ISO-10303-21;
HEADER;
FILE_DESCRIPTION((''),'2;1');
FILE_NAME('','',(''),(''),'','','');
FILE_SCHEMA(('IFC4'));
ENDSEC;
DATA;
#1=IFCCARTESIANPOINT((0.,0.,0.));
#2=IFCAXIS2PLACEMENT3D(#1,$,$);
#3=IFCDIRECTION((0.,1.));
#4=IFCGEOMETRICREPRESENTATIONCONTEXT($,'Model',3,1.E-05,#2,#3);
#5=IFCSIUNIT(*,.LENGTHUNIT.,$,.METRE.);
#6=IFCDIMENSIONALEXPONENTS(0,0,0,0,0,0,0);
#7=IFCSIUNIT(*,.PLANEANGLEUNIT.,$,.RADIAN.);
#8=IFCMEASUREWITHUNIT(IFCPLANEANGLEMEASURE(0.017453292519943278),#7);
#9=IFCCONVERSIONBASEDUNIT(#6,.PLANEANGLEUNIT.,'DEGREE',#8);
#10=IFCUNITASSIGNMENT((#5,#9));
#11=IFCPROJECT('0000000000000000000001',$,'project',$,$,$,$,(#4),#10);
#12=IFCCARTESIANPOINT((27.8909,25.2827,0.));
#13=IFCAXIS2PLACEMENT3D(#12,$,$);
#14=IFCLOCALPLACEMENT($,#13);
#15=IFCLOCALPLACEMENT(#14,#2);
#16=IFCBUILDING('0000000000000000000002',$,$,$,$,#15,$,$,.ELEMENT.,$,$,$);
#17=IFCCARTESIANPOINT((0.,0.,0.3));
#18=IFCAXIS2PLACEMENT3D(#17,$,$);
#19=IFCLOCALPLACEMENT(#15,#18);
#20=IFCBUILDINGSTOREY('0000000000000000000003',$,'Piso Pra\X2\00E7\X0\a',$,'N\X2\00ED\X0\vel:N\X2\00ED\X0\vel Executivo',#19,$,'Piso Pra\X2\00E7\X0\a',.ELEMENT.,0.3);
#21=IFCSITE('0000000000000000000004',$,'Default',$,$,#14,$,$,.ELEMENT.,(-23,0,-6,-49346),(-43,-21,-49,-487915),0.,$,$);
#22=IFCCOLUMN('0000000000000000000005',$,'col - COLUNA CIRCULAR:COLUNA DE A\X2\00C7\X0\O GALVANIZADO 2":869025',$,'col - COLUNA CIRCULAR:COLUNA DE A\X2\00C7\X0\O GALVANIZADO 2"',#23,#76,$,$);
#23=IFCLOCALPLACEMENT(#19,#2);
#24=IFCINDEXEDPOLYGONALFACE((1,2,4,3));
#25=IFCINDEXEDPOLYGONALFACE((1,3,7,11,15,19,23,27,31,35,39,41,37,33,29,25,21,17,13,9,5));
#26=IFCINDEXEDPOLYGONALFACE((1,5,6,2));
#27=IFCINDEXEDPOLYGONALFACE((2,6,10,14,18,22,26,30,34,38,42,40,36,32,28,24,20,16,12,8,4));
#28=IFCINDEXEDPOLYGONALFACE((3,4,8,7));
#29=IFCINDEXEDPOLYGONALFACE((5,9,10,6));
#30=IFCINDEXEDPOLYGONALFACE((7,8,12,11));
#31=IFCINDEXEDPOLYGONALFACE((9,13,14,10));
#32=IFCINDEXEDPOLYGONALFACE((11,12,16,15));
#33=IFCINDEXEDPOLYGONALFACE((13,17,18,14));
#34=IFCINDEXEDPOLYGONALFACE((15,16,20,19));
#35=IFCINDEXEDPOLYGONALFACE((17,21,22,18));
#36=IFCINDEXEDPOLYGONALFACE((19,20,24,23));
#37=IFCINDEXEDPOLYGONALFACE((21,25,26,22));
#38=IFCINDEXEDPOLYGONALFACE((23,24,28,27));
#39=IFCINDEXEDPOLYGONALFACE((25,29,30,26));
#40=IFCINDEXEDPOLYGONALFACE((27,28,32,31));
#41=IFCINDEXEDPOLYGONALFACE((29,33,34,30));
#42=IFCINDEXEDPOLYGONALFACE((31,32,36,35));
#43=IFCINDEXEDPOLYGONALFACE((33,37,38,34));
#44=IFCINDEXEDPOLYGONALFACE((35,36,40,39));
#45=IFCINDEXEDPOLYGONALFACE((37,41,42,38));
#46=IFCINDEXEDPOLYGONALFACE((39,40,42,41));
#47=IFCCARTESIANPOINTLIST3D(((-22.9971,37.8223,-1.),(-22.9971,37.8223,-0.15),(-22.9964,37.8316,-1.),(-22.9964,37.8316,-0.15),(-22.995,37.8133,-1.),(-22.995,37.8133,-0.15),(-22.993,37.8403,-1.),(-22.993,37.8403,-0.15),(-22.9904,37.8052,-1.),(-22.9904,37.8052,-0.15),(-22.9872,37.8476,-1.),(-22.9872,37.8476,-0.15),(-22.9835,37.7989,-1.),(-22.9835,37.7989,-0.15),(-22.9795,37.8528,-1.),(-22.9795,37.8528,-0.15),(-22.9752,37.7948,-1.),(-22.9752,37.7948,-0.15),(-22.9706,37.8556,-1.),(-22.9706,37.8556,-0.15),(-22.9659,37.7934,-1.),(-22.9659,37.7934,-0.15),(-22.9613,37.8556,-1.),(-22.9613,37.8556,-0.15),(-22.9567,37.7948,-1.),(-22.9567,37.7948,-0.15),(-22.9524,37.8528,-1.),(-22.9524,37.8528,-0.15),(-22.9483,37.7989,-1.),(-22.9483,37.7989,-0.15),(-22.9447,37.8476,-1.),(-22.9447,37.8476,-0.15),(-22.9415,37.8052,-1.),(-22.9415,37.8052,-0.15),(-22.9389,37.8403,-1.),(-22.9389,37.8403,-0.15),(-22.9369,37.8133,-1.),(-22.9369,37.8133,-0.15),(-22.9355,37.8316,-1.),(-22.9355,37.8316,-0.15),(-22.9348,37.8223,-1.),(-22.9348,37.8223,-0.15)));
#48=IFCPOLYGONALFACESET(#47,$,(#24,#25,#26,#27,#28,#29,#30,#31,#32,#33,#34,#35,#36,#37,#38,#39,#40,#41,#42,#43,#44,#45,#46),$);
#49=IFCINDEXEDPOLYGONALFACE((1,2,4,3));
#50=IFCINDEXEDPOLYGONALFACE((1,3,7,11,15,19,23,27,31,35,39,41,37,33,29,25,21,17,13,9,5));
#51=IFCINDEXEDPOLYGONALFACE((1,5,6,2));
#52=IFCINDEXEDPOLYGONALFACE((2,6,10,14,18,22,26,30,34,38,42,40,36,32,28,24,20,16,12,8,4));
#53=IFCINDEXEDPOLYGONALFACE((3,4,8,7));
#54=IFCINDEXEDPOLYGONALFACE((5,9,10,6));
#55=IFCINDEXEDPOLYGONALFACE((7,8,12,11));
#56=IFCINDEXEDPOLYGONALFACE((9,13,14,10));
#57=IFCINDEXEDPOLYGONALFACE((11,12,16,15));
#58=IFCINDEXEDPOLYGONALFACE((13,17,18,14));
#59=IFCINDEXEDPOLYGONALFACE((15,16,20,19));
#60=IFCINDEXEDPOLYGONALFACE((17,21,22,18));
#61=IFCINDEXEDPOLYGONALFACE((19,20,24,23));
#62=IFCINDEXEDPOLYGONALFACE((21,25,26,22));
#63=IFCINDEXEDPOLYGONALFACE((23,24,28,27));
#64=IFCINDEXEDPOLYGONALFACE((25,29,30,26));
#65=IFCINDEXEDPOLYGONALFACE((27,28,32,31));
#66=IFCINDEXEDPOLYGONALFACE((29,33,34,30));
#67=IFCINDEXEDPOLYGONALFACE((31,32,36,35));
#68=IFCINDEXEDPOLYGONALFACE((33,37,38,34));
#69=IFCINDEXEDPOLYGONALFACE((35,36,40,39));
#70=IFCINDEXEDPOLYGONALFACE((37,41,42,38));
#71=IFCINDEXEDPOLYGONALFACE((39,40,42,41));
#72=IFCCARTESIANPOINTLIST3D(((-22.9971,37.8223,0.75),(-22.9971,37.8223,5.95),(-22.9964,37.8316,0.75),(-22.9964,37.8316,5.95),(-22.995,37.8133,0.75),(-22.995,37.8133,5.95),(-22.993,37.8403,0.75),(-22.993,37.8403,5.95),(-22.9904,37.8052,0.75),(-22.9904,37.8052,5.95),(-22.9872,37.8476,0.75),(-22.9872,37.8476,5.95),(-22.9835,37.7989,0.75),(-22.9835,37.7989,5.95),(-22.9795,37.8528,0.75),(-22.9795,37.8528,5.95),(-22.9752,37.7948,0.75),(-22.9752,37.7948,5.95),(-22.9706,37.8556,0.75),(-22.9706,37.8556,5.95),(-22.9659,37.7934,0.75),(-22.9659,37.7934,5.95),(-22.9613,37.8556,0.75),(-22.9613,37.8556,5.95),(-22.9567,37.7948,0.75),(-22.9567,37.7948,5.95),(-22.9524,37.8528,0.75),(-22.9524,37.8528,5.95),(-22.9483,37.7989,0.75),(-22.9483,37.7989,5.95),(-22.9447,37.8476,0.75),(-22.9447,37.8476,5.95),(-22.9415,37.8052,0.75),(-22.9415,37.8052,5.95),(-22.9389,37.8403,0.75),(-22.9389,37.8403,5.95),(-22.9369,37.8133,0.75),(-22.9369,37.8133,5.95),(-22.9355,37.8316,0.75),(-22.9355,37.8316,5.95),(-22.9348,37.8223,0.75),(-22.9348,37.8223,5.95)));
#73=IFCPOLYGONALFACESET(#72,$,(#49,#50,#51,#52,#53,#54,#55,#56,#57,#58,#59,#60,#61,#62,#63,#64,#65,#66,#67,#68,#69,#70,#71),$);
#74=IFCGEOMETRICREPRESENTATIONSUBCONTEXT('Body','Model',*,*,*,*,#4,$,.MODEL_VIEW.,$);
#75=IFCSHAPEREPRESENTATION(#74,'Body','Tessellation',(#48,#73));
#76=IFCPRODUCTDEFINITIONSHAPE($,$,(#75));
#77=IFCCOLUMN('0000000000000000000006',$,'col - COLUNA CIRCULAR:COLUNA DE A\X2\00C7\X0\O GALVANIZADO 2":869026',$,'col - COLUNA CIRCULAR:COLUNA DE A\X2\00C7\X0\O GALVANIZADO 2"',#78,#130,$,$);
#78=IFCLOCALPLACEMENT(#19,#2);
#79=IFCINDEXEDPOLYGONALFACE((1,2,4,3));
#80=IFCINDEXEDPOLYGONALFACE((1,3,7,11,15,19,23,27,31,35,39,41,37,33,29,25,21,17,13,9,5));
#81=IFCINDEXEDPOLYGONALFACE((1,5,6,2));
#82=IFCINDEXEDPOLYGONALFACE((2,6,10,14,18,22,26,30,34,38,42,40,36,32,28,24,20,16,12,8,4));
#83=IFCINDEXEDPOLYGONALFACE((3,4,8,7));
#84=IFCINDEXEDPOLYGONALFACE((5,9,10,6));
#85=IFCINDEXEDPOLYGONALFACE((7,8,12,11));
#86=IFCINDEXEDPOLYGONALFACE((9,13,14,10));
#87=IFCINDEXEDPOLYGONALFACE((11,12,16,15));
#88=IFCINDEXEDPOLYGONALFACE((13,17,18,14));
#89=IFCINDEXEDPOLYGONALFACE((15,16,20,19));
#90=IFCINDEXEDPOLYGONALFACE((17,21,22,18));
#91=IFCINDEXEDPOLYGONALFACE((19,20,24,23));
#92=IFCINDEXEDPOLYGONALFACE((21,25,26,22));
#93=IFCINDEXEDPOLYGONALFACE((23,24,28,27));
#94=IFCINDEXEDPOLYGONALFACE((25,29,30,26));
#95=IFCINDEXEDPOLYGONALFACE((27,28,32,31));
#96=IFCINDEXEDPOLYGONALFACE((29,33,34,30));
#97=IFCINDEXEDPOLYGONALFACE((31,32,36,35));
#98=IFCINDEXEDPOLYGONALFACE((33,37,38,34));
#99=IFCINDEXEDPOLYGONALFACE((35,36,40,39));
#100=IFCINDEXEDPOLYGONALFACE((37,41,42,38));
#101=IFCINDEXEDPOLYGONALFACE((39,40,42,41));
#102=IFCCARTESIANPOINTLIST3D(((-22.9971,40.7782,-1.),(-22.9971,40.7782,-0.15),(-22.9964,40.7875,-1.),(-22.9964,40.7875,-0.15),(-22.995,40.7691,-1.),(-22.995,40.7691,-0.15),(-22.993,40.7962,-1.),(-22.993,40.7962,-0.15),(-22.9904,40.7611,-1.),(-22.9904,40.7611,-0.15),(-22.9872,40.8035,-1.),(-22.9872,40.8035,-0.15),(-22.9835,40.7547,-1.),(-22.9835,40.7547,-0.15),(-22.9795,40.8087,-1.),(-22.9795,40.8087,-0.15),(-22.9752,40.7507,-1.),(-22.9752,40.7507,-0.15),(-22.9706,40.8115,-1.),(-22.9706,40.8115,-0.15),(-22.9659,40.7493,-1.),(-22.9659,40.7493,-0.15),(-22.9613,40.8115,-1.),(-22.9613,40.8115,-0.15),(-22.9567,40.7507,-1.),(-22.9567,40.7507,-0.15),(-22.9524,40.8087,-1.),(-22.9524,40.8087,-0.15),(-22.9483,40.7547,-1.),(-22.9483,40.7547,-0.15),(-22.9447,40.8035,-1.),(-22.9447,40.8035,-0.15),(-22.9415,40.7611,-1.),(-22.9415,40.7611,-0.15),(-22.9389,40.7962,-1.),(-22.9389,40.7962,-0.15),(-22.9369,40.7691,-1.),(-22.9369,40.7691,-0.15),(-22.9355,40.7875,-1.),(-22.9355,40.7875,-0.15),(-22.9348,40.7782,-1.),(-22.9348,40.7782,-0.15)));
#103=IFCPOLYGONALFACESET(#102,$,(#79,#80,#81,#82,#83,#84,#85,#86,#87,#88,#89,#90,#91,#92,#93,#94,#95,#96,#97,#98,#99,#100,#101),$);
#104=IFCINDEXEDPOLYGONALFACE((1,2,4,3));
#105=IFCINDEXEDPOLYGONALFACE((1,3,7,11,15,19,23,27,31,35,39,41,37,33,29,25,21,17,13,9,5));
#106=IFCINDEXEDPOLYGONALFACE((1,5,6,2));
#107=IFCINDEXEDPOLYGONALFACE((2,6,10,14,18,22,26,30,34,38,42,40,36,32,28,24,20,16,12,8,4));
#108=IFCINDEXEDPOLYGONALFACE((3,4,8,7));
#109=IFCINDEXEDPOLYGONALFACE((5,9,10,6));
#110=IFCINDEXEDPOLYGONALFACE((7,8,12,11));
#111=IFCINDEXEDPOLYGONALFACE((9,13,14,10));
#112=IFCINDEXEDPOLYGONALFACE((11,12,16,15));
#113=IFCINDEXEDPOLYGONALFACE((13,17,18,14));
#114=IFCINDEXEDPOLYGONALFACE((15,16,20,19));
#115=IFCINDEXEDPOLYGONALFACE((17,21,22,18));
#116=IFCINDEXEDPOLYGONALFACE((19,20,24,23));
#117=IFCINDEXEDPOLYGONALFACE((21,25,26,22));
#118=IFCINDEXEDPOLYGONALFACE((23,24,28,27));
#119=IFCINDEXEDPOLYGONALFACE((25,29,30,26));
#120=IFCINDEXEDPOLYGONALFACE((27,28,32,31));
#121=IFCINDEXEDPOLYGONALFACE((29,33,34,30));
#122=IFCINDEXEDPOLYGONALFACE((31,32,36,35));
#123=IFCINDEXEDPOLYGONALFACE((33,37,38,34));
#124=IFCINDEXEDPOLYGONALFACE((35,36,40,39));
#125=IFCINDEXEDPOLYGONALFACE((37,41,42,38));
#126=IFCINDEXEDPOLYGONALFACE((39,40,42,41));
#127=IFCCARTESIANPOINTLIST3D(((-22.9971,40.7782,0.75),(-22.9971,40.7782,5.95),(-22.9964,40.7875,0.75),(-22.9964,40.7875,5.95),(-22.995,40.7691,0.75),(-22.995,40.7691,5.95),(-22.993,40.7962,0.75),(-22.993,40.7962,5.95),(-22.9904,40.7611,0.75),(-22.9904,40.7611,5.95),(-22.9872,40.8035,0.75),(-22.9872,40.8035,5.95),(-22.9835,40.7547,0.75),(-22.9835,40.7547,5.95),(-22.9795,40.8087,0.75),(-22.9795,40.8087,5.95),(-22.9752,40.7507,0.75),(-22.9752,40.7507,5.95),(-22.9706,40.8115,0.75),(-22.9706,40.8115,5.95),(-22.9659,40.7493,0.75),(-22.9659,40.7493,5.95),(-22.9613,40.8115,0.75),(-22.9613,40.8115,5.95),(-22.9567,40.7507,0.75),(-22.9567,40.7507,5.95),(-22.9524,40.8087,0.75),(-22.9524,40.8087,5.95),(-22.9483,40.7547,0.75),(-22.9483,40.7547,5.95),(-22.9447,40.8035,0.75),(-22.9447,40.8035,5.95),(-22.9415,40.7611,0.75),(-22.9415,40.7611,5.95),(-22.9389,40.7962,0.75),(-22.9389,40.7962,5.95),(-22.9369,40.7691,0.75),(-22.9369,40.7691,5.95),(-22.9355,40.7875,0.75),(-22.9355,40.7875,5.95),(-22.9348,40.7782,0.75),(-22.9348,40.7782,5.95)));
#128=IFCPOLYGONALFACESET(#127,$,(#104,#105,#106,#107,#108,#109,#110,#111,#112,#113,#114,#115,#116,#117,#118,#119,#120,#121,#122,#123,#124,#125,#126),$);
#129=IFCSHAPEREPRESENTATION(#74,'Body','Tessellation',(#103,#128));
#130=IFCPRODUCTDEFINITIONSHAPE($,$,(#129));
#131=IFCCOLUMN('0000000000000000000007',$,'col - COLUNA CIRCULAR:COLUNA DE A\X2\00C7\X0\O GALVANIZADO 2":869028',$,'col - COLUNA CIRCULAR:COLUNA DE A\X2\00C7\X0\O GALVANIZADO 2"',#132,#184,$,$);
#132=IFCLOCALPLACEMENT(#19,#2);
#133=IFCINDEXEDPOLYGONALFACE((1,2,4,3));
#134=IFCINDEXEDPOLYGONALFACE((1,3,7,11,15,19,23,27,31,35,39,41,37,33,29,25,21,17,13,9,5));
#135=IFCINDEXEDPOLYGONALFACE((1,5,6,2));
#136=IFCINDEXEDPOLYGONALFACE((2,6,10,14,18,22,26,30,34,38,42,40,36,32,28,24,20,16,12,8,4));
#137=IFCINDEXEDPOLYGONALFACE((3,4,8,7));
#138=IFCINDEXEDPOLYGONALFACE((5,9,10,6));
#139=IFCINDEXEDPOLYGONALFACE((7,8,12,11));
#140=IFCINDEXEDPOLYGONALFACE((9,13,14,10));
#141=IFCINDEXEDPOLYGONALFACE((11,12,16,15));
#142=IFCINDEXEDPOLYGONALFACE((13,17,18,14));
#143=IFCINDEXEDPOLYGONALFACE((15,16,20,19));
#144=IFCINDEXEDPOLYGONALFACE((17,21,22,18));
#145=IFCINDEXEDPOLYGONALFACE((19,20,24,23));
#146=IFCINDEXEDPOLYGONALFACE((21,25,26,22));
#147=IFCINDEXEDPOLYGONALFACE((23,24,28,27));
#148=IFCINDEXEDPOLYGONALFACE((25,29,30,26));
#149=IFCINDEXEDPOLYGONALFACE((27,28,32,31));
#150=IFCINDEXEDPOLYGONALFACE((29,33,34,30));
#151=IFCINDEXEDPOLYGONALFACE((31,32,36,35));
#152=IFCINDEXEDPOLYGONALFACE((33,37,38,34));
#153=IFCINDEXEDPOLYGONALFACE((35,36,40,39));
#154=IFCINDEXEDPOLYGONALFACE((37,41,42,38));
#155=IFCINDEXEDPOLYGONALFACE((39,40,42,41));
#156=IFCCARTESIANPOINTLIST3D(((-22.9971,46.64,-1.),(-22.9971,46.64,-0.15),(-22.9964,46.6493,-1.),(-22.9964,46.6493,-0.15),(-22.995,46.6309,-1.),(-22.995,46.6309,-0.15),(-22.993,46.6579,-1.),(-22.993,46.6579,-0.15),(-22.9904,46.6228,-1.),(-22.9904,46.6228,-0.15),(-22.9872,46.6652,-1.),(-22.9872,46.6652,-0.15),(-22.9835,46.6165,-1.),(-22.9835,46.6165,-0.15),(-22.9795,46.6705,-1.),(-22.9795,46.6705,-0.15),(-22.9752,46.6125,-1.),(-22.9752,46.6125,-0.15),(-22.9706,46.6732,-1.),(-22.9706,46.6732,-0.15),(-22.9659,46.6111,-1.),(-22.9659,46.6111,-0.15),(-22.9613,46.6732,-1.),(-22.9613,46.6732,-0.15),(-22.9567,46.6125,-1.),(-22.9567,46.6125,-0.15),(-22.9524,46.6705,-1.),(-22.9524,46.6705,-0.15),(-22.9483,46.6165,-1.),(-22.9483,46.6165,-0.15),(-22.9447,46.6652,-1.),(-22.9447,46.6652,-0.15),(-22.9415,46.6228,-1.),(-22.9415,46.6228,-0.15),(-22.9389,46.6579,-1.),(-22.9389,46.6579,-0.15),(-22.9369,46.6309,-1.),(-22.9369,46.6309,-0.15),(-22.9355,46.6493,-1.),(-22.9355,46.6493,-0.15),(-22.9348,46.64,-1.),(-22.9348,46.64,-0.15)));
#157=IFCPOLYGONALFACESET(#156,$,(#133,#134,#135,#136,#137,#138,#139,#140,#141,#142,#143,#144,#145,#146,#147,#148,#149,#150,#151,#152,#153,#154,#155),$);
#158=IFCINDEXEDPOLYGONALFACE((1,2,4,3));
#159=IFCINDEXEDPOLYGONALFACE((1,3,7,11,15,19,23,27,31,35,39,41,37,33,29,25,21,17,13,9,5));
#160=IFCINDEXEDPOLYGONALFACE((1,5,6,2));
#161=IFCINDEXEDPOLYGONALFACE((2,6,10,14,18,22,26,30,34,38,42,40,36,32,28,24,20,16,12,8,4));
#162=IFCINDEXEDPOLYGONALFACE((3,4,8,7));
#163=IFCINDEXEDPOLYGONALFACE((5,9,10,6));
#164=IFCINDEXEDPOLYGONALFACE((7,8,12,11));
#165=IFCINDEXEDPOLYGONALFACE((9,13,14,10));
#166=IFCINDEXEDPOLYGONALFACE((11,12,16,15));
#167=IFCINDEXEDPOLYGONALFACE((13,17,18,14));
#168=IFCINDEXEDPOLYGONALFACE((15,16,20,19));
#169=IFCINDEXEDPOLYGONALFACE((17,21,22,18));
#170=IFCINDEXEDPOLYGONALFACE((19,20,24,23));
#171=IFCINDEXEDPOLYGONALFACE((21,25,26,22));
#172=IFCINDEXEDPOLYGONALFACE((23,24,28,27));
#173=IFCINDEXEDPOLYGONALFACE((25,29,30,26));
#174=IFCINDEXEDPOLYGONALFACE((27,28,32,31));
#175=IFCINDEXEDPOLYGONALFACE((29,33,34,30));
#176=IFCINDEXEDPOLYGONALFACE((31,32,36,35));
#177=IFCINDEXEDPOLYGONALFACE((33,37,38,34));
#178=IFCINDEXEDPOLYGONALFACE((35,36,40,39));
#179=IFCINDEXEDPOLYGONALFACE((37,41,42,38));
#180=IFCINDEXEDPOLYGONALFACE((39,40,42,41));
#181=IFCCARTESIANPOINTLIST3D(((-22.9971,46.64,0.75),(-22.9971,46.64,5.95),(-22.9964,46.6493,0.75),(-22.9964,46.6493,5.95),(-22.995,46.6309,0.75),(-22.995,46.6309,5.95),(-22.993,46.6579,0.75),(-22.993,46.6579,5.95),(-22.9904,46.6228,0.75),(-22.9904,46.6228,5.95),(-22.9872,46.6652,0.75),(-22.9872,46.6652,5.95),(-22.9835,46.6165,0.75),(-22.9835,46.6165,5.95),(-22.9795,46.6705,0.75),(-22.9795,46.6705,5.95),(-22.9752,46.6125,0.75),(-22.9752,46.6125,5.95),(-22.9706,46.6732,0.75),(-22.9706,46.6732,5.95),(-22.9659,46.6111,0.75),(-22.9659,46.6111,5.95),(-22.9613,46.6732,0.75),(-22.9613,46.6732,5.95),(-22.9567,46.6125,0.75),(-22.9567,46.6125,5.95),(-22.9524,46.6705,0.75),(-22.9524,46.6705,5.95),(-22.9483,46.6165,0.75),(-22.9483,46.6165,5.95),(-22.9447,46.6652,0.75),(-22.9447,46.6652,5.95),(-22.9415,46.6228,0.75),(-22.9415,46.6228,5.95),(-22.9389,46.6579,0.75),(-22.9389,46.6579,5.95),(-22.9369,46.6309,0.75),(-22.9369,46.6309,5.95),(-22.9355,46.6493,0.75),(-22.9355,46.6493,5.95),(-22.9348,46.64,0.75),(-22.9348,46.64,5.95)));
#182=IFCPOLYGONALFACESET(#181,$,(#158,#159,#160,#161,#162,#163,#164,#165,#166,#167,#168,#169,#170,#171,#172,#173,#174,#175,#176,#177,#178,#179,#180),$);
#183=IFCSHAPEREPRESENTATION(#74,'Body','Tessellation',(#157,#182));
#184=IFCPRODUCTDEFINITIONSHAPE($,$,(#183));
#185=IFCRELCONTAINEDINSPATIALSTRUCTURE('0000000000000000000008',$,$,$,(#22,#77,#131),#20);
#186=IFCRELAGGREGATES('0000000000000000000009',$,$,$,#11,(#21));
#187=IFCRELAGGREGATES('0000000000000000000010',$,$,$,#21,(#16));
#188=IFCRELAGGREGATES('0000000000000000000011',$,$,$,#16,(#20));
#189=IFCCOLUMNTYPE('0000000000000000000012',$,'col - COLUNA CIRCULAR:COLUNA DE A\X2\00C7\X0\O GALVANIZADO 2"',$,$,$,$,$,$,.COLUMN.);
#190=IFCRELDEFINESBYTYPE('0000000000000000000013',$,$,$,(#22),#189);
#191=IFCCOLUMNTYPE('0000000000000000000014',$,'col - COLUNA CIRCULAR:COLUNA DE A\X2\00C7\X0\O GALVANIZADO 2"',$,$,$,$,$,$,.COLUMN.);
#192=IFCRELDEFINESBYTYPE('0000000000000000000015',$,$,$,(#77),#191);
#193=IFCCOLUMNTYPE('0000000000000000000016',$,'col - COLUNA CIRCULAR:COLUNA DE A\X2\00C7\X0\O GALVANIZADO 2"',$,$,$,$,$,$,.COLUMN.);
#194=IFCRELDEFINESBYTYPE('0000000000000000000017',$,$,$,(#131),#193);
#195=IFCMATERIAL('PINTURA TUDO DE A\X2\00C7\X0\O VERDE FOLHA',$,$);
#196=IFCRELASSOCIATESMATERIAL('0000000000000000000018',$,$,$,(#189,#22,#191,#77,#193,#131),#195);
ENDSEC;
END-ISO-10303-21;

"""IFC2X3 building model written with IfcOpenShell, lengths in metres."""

from ifc_helpers import new_model, entity, si_unit, converted_unit, direction, frame, origin, origin_2d_with_axis, place, context, subcontext, project, spatial, circle, extrude, source, transform, mapped, material, type_object, type_shapes, element, save


model = new_model("IFC2X3")

# Units and contexts
model_context = context("Model", 3, precision=1e-05, world=origin(), true_north=direction((0.0, 1.0)))
body_context = subcontext(model_context, "Body", "Model", "MODEL_VIEW")
ifc_project = project(units=[si_unit("LENGTHUNIT", "METRE"), converted_unit("PLANEANGLEUNIT", "DEGREE", entity("IfcPlaneAngleMeasure", 0.017453292519943278), si_unit("PLANEANGLEUNIT", "RADIAN"), dimensions=[0, 0, 0, 0, 0, 0, 0])], contexts=[model_context])

# Site, building, storey
site_placement = place(None, frame((27.8909, 25.2827, 0.0)))
site = spatial("IfcSite", under=ifc_project, at=site_placement, Name="Default", CompositionType="ELEMENT", RefLatitude=(-23, 0, -6, -49346), RefLongitude=(-43, -21, -49, -487915), RefElevation=0.0)
building_placement = place(site_placement, origin())
building = spatial("IfcBuilding", under=site, at=building_placement, CompositionType="ELEMENT")
storey_placement = place(building_placement, frame((0.0, 0.0, 0.3)))
storey = spatial("IfcBuildingStorey", under=building, at=storey_placement, Name="Piso Praça", ObjectType="Nível:Nível Executivo", LongName="Piso Praça", CompositionType="ELEMENT", Elevation=0.3)

# Columns
ifc_material = material(Name="PINTURA TUDO DE AÇO VERDE FOLHA")
column_type_1 = type_object("IfcColumnType", Name="col - COLUNA CIRCULAR:COLUNA DE AÇO GALVANIZADO 2\"", PredefinedType="COLUMN", material=ifc_material)
shared_shape_1 = source(origin(), body_context, "Body", "SweptSolid", [
    extrude(circle(Radius=0.0312, at=origin_2d_with_axis()), frame((-22.9659, 37.8247, -0.7), z_axis=(0.0, 0.0, 1.0), x_axis=(0.0, -1.0, 0.0)), (0.0, 0.0, 1.0), 0.85),
    extrude(circle(Radius=0.0312, at=origin_2d_with_axis()), frame((-22.9659, 37.8247, 1.05), z_axis=(0.0, 0.0, 1.0), x_axis=(0.0, -1.0, 0.0)), (0.0, 0.0, 1.0), 5.2),
])
type_shapes(column_type_1, [shared_shape_1])
column_1_placement = place(storey_placement, frame((0.0, 0.0, -0.3)))
element("IfcColumn", 1, at=column_1_placement, inside=storey, type_object=column_type_1, material=ifc_material, Name="col - COLUNA CIRCULAR:COLUNA DE AÇO GALVANIZADO 2\":869025", ObjectType="col - COLUNA CIRCULAR:COLUNA DE AÇO GALVANIZADO 2\"", context=body_context, shape_type="MappedRepresentation", body=[
    mapped(shared_shape_1, transform((0.0, 0.0, 0.0), scale=1.0)),
])
column_type_2 = type_object("IfcColumnType", Name="col - COLUNA CIRCULAR:COLUNA DE AÇO GALVANIZADO 2\"", PredefinedType="COLUMN", material=ifc_material)
shared_shape_2 = source(origin(), body_context, "Body", "SweptSolid", [
    extrude(circle(Radius=0.0312, at=origin_2d_with_axis()), frame((-22.9659, 40.7806, -0.7), z_axis=(0.0, 0.0, 1.0), x_axis=(0.0, -1.0, 0.0)), (0.0, 0.0, 1.0), 0.85),
    extrude(circle(Radius=0.0312, at=origin_2d_with_axis()), frame((-22.9659, 40.7806, 1.05), z_axis=(0.0, 0.0, 1.0), x_axis=(0.0, -1.0, 0.0)), (0.0, 0.0, 1.0), 5.2),
])
type_shapes(column_type_2, [shared_shape_2])
column_2_placement = place(storey_placement, frame((0.0, 0.0, -0.3)))
element("IfcColumn", 2, at=column_2_placement, inside=storey, type_object=column_type_2, material=ifc_material, Name="col - COLUNA CIRCULAR:COLUNA DE AÇO GALVANIZADO 2\":869026", ObjectType="col - COLUNA CIRCULAR:COLUNA DE AÇO GALVANIZADO 2\"", context=body_context, shape_type="MappedRepresentation", body=[
    mapped(shared_shape_2, transform((0.0, 0.0, 0.0), scale=1.0)),
])
column_type_3 = type_object("IfcColumnType", Name="col - COLUNA CIRCULAR:COLUNA DE AÇO GALVANIZADO 2\"", PredefinedType="COLUMN", material=ifc_material)
shared_shape_3 = source(origin(), body_context, "Body", "SweptSolid", [
    extrude(circle(Radius=0.0312, at=origin_2d_with_axis()), frame((-22.9659, 46.6423, -0.7), z_axis=(0.0, 0.0, 1.0), x_axis=(0.0, -1.0, 0.0)), (0.0, 0.0, 1.0), 0.85),
    extrude(circle(Radius=0.0312, at=origin_2d_with_axis()), frame((-22.9659, 46.6423, 1.05), z_axis=(0.0, 0.0, 1.0), x_axis=(0.0, -1.0, 0.0)), (0.0, 0.0, 1.0), 5.2),
])
type_shapes(column_type_3, [shared_shape_3])
column_3_placement = place(storey_placement, frame((0.0, 0.0, -0.3)))
element("IfcColumn", 3, at=column_3_placement, inside=storey, type_object=column_type_3, material=ifc_material, Name="col - COLUNA CIRCULAR:COLUNA DE AÇO GALVANIZADO 2\":869028", ObjectType="col - COLUNA CIRCULAR:COLUNA DE AÇO GALVANIZADO 2\"", context=body_context, shape_type="MappedRepresentation", body=[
    mapped(shared_shape_3, transform((0.0, 0.0, 0.0), scale=1.0)),
])

save(model, "model.ifc")
